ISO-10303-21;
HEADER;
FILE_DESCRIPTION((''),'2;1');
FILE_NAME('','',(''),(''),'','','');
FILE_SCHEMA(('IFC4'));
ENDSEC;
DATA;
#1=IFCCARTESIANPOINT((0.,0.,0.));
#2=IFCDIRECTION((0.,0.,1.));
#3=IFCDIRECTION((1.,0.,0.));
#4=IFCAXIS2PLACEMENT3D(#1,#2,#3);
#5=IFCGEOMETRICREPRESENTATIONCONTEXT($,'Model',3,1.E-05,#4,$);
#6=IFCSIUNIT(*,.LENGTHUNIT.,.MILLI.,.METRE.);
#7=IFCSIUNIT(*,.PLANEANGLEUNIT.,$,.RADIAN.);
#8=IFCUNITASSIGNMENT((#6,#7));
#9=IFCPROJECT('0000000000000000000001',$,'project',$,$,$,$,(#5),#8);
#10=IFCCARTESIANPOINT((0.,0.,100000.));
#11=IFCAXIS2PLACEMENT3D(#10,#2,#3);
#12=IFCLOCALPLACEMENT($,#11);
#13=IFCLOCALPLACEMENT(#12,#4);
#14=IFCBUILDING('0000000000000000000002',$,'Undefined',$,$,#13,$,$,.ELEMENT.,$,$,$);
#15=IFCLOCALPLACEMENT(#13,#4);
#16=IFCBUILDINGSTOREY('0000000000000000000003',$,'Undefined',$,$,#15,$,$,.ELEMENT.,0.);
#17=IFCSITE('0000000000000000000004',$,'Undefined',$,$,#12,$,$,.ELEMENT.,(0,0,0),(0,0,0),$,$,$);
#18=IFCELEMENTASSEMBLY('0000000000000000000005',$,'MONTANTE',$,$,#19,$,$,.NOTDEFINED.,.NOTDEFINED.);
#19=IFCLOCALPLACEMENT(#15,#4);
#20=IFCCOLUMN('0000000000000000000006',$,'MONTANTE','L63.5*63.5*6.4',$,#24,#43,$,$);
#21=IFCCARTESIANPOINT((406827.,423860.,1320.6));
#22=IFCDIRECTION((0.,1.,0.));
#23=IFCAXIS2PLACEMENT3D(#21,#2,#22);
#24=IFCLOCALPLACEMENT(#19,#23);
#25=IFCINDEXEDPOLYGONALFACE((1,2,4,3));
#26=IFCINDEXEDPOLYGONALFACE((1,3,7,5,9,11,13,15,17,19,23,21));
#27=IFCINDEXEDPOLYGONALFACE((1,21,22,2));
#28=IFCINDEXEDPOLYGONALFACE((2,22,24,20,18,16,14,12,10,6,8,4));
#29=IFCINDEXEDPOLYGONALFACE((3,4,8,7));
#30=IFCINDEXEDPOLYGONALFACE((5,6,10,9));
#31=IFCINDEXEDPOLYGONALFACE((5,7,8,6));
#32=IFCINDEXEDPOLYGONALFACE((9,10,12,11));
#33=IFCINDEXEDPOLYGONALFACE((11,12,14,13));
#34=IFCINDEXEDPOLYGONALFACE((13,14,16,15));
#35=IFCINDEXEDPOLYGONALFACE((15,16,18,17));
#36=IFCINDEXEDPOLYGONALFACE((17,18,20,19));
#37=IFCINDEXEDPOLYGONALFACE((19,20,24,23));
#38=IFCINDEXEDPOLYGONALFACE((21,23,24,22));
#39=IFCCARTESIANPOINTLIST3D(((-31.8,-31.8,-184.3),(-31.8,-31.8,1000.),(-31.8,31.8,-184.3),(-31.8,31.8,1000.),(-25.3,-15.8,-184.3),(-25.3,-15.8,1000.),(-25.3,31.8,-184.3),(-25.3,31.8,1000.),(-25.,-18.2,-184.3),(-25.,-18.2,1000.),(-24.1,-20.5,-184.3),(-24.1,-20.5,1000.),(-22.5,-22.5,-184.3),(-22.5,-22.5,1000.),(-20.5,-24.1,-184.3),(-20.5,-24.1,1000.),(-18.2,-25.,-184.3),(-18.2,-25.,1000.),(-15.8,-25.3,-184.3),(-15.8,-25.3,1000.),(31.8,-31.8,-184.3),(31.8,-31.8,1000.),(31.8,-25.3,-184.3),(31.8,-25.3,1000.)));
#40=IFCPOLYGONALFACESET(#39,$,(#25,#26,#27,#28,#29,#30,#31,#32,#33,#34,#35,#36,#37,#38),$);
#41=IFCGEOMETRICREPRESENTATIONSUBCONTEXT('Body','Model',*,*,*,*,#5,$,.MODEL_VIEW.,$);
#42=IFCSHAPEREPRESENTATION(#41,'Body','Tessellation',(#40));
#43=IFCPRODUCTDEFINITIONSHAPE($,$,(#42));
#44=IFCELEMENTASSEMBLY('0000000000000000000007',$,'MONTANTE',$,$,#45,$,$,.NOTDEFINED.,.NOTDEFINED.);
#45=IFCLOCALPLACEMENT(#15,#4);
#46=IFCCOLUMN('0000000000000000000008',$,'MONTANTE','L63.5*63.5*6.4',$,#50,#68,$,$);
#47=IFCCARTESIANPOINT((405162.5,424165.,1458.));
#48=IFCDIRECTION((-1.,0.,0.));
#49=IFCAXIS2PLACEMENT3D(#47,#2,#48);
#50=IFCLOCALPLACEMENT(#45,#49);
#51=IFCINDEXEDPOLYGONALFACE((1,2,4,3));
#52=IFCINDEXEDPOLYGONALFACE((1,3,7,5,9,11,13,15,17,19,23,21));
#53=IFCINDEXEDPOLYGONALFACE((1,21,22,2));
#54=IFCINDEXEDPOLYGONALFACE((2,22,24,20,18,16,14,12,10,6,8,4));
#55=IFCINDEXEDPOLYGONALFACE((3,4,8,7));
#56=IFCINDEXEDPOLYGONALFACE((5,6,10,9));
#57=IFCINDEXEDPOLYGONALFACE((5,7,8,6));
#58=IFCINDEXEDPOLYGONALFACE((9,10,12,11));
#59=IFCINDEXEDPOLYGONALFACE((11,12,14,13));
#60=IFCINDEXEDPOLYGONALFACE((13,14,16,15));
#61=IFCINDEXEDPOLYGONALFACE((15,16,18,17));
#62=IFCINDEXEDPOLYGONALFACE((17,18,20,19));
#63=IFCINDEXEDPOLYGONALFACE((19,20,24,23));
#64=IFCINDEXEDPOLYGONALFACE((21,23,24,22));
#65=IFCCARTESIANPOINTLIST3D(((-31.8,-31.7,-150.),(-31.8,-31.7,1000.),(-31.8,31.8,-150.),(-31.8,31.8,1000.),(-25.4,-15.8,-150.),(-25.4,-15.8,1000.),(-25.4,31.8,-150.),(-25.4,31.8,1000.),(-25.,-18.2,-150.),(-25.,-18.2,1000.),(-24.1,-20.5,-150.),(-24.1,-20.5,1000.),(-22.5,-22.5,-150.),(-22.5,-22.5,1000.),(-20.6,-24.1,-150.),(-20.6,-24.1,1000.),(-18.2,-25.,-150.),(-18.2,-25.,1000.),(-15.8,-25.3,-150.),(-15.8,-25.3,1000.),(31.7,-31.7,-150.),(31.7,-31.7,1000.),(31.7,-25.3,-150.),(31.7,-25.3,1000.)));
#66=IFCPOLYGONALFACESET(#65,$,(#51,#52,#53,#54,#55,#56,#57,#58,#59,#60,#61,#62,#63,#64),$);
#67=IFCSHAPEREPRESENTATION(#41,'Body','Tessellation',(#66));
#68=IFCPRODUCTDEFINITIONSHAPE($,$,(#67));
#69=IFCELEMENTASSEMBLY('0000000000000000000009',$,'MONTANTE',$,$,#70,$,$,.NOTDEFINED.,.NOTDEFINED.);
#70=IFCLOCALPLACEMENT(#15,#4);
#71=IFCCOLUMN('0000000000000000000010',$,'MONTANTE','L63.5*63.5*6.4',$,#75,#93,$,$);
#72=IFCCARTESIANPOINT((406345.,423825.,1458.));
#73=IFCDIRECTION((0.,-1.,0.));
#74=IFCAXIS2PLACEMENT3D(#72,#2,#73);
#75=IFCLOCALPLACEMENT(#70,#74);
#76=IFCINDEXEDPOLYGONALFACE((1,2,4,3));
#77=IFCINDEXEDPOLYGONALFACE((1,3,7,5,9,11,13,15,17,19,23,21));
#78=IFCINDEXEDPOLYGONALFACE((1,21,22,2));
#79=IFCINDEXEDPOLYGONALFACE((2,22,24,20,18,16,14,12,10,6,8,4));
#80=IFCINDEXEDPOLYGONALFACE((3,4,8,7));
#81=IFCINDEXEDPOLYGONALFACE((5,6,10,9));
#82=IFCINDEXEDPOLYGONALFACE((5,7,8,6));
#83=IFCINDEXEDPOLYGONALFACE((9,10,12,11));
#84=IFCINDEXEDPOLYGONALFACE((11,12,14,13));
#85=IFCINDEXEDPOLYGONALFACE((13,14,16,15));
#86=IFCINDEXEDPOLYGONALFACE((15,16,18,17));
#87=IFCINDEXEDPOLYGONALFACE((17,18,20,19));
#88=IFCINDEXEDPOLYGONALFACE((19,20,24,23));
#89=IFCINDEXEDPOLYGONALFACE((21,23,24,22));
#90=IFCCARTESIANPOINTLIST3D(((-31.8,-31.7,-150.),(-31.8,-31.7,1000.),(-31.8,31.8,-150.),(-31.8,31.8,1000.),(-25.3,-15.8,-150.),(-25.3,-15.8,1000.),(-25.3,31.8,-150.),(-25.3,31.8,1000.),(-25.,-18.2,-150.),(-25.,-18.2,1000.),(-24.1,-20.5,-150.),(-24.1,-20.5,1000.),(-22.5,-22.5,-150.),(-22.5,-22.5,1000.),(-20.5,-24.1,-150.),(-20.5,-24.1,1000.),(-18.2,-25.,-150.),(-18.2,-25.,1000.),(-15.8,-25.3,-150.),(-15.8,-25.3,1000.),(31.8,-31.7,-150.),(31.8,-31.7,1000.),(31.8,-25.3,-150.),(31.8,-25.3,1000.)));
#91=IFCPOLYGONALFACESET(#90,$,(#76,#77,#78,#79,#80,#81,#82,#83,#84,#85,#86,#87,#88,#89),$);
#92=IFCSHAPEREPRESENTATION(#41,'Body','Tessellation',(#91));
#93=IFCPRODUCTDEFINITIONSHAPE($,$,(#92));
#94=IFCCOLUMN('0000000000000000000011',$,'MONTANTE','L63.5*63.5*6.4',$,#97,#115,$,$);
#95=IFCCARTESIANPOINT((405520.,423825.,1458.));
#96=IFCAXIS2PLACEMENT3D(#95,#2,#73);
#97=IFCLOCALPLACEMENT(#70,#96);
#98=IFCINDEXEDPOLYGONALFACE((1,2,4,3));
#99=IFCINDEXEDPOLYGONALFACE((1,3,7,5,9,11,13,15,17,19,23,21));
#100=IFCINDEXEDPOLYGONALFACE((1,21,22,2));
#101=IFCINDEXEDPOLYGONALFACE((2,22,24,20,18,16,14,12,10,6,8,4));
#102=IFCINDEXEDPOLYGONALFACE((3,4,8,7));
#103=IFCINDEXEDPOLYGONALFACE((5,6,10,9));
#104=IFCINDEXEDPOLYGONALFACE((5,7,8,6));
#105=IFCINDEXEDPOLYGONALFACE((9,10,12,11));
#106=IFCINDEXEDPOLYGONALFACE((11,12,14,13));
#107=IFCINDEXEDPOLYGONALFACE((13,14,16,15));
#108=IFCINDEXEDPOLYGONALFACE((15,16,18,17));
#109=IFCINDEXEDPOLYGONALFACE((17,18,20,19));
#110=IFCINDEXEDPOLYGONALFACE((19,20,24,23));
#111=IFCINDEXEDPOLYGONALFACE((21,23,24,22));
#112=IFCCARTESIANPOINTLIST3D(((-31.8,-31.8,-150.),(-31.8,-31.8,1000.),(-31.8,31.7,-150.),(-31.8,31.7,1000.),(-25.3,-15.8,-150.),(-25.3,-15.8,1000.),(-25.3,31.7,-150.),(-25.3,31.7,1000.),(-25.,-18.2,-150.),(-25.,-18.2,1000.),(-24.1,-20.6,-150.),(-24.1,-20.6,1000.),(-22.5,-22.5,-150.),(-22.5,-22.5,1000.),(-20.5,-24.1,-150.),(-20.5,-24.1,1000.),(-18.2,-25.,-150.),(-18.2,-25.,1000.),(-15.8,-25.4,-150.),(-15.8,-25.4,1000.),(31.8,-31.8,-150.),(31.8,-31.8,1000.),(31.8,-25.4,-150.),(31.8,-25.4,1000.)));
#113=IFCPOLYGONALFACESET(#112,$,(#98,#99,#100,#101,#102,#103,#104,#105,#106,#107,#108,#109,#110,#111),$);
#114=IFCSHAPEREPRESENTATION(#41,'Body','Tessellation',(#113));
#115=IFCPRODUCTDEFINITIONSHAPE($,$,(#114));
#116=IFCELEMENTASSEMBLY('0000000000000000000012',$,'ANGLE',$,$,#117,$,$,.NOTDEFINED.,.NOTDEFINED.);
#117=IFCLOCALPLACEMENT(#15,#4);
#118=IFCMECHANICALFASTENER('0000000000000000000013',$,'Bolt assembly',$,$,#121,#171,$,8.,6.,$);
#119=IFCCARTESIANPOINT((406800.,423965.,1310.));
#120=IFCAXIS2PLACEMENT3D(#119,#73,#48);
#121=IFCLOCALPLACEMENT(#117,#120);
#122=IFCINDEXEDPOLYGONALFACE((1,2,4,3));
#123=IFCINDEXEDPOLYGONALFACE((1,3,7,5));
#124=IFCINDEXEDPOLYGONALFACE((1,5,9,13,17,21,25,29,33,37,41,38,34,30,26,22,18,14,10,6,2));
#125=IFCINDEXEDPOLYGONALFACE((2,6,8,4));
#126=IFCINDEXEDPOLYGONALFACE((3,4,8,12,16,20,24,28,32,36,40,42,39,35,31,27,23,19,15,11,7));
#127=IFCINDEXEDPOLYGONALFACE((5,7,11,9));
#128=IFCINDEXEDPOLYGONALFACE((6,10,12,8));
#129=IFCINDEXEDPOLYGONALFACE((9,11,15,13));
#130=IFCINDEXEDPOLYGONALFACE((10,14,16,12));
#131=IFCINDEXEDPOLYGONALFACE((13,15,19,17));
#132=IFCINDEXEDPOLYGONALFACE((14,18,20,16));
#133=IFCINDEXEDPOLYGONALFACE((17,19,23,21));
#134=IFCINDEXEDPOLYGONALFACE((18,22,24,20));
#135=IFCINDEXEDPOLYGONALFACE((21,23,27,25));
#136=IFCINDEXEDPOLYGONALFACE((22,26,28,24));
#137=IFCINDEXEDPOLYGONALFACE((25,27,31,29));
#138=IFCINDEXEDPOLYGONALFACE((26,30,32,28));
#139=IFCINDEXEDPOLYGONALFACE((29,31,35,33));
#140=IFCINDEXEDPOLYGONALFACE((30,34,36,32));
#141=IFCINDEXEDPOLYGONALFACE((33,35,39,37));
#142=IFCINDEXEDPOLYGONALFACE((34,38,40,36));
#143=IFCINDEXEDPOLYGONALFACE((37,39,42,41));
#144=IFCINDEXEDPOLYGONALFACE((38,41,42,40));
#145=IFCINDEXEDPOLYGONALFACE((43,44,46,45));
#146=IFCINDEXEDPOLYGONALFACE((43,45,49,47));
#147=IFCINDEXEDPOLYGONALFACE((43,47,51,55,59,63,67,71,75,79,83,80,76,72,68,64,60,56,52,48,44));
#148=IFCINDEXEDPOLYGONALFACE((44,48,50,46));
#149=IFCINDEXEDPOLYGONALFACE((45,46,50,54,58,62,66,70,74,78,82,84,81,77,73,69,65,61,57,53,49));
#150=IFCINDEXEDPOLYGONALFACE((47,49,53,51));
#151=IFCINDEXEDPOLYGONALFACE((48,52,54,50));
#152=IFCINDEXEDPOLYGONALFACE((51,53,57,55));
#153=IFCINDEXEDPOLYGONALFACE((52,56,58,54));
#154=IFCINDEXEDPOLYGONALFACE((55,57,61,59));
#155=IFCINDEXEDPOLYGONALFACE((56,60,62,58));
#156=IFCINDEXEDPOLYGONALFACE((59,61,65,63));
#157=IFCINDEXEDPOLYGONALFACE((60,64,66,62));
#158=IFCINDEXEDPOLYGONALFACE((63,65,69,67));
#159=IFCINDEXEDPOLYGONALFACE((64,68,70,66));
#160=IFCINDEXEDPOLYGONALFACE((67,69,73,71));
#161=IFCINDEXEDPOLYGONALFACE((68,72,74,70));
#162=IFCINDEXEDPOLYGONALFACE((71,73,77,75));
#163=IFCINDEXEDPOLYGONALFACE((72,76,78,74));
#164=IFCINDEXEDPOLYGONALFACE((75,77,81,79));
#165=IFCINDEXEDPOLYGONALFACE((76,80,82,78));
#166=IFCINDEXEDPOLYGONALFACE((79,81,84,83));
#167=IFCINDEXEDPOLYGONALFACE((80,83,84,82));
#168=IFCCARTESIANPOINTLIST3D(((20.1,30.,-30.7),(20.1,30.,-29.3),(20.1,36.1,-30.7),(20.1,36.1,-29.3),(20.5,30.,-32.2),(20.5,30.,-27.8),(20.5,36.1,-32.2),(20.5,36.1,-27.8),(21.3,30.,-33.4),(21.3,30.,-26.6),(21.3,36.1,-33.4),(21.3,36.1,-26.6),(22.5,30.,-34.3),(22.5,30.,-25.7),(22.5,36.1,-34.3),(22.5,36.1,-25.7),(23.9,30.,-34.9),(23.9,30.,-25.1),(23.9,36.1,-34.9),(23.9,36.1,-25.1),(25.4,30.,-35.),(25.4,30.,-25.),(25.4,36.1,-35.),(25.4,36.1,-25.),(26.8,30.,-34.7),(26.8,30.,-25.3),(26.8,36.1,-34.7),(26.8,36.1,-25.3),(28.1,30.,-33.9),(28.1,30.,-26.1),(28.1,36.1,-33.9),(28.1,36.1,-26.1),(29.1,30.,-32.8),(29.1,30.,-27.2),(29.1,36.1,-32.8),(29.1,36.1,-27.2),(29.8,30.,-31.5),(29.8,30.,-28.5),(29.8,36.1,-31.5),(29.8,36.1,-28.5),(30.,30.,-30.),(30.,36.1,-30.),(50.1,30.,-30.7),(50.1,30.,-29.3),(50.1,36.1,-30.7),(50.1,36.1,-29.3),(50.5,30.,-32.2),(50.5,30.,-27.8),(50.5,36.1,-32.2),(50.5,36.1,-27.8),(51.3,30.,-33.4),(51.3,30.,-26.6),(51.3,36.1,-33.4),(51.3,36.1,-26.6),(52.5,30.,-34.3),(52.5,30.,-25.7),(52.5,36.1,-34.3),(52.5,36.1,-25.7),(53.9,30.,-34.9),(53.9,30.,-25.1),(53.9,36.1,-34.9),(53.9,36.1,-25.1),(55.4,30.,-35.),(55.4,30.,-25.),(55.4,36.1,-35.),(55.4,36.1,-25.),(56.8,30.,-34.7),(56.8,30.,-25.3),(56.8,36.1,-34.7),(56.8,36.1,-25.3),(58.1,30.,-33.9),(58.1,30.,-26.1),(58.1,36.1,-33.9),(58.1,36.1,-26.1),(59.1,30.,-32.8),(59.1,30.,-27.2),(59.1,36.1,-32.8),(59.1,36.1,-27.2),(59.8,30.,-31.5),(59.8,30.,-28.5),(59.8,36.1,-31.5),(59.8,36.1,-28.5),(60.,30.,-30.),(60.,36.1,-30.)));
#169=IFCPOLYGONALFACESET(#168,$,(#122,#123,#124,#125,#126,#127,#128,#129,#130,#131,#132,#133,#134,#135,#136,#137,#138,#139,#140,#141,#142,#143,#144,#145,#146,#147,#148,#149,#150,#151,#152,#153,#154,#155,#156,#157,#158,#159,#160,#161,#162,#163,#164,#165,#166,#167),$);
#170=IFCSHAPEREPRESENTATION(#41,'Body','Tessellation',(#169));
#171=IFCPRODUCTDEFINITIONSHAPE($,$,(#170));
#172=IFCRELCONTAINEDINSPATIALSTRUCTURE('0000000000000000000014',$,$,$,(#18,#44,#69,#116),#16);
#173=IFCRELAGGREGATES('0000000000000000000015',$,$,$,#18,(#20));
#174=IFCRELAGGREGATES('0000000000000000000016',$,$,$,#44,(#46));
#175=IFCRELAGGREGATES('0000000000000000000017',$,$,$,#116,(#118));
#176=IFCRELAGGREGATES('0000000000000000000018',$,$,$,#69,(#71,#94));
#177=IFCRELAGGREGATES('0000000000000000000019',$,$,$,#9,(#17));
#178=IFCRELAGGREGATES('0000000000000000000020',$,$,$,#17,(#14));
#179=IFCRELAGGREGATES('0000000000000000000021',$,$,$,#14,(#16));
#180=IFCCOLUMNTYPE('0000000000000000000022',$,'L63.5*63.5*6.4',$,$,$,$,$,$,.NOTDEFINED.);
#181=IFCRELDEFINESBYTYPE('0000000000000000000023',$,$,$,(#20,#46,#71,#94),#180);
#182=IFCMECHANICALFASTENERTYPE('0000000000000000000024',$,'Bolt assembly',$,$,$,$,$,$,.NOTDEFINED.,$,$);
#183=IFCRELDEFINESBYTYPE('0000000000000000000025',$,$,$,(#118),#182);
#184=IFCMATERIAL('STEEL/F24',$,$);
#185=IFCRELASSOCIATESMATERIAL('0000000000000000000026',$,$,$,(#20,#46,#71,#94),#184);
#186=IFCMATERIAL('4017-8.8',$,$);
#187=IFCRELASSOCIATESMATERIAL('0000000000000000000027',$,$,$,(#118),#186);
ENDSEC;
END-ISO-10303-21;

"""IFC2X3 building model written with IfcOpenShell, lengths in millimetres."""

from ifc_helpers import new_model, si_unit, frame, origin_with_axes, origin_2d_with_axis, place, context, subcontext, project, spatial, circle, l_section, extrude, clip, halfspace, source, transform, mapped, material, type_object, element, aggregate, save


model = new_model("IFC2X3")

# Units and contexts
model_context = context("Model", 3, precision=1e-05, world=origin_with_axes())
body_context = subcontext(model_context, "Body", "Model", "MODEL_VIEW")
ifc_project = project(units=[si_unit("LENGTHUNIT", "METRE", prefix="MILLI"), si_unit("PLANEANGLEUNIT", "RADIAN")], contexts=[model_context])

# Site, building, storey
site_placement = place(None, frame((0.0, 0.0, 100000.0), z_axis=(0.0, 0.0, 1.0), x_axis=(1.0, 0.0, 0.0)))
site = spatial("IfcSite", under=ifc_project, at=site_placement, Name="Undefined", CompositionType="ELEMENT", RefLatitude=(0, 0, 0), RefLongitude=(0, 0, 0))
building_placement = place(site_placement, origin_with_axes())
building = spatial("IfcBuilding", under=site, at=building_placement, Name="Undefined", CompositionType="ELEMENT")
storey_placement = place(building_placement, origin_with_axes())
storey = spatial("IfcBuildingStorey", under=building, at=storey_placement, Name="Undefined", CompositionType="ELEMENT", Elevation=0.0)

# Element assemblies, columns
assembly_1_placement = place(storey_placement, origin_with_axes())
assembly_1 = element("IfcElementAssembly", 1, at=assembly_1_placement, inside=storey, Name="MONTANTE", AssemblyPlace="NOTDEFINED", PredefinedType="NOTDEFINED")
ifc_material_1 = material(Name="STEEL/F24")
column_type = type_object("IfcColumnType", Name="L63.5*63.5*6.4", PredefinedType="NOTDEFINED")
column_1_placement = place(assembly_1_placement, frame((406827.0, 423860.0, 1320.6), z_axis=(0.0, 0.0, 1.0), x_axis=(0.0, 1.0, 0.0)))
column_1 = element("IfcColumn", 2, at=column_1_placement, type_object=column_type, material=ifc_material_1, Name="MONTANTE", Description="L63.5*63.5*6.4", context=body_context, shape_type="Clipping", body=[
    clip(extrude(l_section(Depth=63.5, Width=63.5, Thickness=6.4, FilletRadius=9.6, at=origin_2d_with_axis()), frame((0.0, 0.0, 1000.0), z_axis=(0.0, 0.0, -1.0), x_axis=(0.0, 1.0, 0.0)), (0.0, 0.0, 1.0), 1184.3), halfspace(frame((0.0, 0.0, -184.3), z_axis=(0.0, 0.0, -1.0), x_axis=(0.0, -1.0, 0.0)), False)),
])
assembly_2_placement = place(storey_placement, origin_with_axes())
assembly_2 = element("IfcElementAssembly", 3, at=assembly_2_placement, inside=storey, Name="MONTANTE", AssemblyPlace="NOTDEFINED", PredefinedType="NOTDEFINED")
column_2_placement = place(assembly_2_placement, frame((405162.5, 424165.0, 1458.0), z_axis=(0.0, 0.0, 1.0), x_axis=(-1.0, 0.0, 0.0)))
column_2 = element("IfcColumn", 4, at=column_2_placement, type_object=column_type, material=ifc_material_1, Name="MONTANTE", Description="L63.5*63.5*6.4", context=body_context, shape_type="Clipping", body=[
    clip(extrude(l_section(Depth=63.5, Width=63.5, Thickness=6.4, FilletRadius=9.6, at=origin_2d_with_axis()), frame((0.0, 0.0, 1000.0), z_axis=(0.0, 0.0, -1.0), x_axis=(0.0, 1.0, 0.0)), (0.0, 0.0, 1.0), 1150.0), halfspace(frame((0.0, 0.0, -150.0), z_axis=(0.0, 0.0, -1.0), x_axis=(0.0, 1.0, 0.0)), False)),
])

# Element assembly, columns
assembly_3_placement = place(storey_placement, origin_with_axes())
assembly_3 = element("IfcElementAssembly", 5, at=assembly_3_placement, inside=storey, Name="MONTANTE", AssemblyPlace="NOTDEFINED", PredefinedType="NOTDEFINED")
column_3_placement = place(assembly_3_placement, frame((406345.0, 423825.0, 1458.0), z_axis=(0.0, 0.0, 1.0), x_axis=(0.0, -1.0, 0.0)))
column_3 = element("IfcColumn", 6, at=column_3_placement, type_object=column_type, material=ifc_material_1, Name="MONTANTE", Description="L63.5*63.5*6.4", context=body_context, shape_type="Clipping", body=[
    clip(extrude(l_section(Depth=63.5, Width=63.5, Thickness=6.4, FilletRadius=9.6, at=origin_2d_with_axis()), frame((0.0, 0.0, 1000.0), z_axis=(0.0, 0.0, -1.0), x_axis=(0.0, 1.0, 0.0)), (0.0, 0.0, 1.0), 1150.0), halfspace(frame((0.0, -450.0, -150.0), z_axis=(0.0, 0.0, -1.0), x_axis=(0.0, 1.0, 0.0)), False)),
])
column_4_placement = place(assembly_3_placement, frame((405520.0, 423825.0, 1458.0), z_axis=(0.0, 0.0, 1.0), x_axis=(0.0, -1.0, 0.0)))
column_4 = element("IfcColumn", 7, at=column_4_placement, type_object=column_type, material=ifc_material_1, Name="MONTANTE", Description="L63.5*63.5*6.4", context=body_context, shape_type="Clipping", body=[
    clip(extrude(l_section(Depth=63.5, Width=63.5, Thickness=6.4, FilletRadius=9.6, at=origin_2d_with_axis()), frame((0.0, 0.0, 1000.0), z_axis=(0.0, 0.0, -1.0), x_axis=(0.0, 1.0, 0.0)), (0.0, 0.0, 1.0), 1150.0), halfspace(frame((0.0, 0.0, -150.0), z_axis=(0.0, 0.0, -1.0), x_axis=(0.0, 1.0, 0.0)), False)),
])

# Element assembly
assembly_4_placement = place(storey_placement, origin_with_axes())
assembly_4 = element("IfcElementAssembly", 8, at=assembly_4_placement, inside=storey, Name="ANGLE", AssemblyPlace="NOTDEFINED", PredefinedType="NOTDEFINED")

# Shared definitions
ifc_material_2 = material(Name="4017-8.8")
mechanical_fastener_type = type_object("IfcMechanicalFastenerType", Name="Bolt assembly")
aggregate(assembly_1, [column_1])

# Mechanical fastener
aggregate(assembly_2, [column_2])
shared_shape_1 = source(origin_with_axes(), body_context, "Body", "SweptSolid", [
    extrude(circle(Radius=5.0, at=origin_2d_with_axis()), frame((0.0, 30.0, 0.0), z_axis=(0.0, 1.0, 0.0), x_axis=(1.0, 0.0, 0.0)), (0.0, 0.0, 1.0), 6.1),
])
mechanical_fastener_1_placement = place(assembly_4_placement, frame((406800.0, 423965.0, 1310.0), z_axis=(0.0, -1.0, 0.0), x_axis=(-1.0, 0.0, 0.0)))
mechanical_fastener_1 = element("IfcMechanicalFastener", 9, at=mechanical_fastener_1_placement, type_object=mechanical_fastener_type, material=ifc_material_2, Name="Bolt assembly", NominalDiameter=8.0, NominalLength=6.0, context=body_context, shape_type="MappedRepresentation", body=[
    mapped(shared_shape_1, transform((25.0, 0.0, -30.0))),
    mapped(shared_shape_1, transform((55.0, 0.0, -30.0))),
])
aggregate(assembly_4, [mechanical_fastener_1])

aggregate(assembly_3, [column_3, column_4])

save(model, "model.ifc")
